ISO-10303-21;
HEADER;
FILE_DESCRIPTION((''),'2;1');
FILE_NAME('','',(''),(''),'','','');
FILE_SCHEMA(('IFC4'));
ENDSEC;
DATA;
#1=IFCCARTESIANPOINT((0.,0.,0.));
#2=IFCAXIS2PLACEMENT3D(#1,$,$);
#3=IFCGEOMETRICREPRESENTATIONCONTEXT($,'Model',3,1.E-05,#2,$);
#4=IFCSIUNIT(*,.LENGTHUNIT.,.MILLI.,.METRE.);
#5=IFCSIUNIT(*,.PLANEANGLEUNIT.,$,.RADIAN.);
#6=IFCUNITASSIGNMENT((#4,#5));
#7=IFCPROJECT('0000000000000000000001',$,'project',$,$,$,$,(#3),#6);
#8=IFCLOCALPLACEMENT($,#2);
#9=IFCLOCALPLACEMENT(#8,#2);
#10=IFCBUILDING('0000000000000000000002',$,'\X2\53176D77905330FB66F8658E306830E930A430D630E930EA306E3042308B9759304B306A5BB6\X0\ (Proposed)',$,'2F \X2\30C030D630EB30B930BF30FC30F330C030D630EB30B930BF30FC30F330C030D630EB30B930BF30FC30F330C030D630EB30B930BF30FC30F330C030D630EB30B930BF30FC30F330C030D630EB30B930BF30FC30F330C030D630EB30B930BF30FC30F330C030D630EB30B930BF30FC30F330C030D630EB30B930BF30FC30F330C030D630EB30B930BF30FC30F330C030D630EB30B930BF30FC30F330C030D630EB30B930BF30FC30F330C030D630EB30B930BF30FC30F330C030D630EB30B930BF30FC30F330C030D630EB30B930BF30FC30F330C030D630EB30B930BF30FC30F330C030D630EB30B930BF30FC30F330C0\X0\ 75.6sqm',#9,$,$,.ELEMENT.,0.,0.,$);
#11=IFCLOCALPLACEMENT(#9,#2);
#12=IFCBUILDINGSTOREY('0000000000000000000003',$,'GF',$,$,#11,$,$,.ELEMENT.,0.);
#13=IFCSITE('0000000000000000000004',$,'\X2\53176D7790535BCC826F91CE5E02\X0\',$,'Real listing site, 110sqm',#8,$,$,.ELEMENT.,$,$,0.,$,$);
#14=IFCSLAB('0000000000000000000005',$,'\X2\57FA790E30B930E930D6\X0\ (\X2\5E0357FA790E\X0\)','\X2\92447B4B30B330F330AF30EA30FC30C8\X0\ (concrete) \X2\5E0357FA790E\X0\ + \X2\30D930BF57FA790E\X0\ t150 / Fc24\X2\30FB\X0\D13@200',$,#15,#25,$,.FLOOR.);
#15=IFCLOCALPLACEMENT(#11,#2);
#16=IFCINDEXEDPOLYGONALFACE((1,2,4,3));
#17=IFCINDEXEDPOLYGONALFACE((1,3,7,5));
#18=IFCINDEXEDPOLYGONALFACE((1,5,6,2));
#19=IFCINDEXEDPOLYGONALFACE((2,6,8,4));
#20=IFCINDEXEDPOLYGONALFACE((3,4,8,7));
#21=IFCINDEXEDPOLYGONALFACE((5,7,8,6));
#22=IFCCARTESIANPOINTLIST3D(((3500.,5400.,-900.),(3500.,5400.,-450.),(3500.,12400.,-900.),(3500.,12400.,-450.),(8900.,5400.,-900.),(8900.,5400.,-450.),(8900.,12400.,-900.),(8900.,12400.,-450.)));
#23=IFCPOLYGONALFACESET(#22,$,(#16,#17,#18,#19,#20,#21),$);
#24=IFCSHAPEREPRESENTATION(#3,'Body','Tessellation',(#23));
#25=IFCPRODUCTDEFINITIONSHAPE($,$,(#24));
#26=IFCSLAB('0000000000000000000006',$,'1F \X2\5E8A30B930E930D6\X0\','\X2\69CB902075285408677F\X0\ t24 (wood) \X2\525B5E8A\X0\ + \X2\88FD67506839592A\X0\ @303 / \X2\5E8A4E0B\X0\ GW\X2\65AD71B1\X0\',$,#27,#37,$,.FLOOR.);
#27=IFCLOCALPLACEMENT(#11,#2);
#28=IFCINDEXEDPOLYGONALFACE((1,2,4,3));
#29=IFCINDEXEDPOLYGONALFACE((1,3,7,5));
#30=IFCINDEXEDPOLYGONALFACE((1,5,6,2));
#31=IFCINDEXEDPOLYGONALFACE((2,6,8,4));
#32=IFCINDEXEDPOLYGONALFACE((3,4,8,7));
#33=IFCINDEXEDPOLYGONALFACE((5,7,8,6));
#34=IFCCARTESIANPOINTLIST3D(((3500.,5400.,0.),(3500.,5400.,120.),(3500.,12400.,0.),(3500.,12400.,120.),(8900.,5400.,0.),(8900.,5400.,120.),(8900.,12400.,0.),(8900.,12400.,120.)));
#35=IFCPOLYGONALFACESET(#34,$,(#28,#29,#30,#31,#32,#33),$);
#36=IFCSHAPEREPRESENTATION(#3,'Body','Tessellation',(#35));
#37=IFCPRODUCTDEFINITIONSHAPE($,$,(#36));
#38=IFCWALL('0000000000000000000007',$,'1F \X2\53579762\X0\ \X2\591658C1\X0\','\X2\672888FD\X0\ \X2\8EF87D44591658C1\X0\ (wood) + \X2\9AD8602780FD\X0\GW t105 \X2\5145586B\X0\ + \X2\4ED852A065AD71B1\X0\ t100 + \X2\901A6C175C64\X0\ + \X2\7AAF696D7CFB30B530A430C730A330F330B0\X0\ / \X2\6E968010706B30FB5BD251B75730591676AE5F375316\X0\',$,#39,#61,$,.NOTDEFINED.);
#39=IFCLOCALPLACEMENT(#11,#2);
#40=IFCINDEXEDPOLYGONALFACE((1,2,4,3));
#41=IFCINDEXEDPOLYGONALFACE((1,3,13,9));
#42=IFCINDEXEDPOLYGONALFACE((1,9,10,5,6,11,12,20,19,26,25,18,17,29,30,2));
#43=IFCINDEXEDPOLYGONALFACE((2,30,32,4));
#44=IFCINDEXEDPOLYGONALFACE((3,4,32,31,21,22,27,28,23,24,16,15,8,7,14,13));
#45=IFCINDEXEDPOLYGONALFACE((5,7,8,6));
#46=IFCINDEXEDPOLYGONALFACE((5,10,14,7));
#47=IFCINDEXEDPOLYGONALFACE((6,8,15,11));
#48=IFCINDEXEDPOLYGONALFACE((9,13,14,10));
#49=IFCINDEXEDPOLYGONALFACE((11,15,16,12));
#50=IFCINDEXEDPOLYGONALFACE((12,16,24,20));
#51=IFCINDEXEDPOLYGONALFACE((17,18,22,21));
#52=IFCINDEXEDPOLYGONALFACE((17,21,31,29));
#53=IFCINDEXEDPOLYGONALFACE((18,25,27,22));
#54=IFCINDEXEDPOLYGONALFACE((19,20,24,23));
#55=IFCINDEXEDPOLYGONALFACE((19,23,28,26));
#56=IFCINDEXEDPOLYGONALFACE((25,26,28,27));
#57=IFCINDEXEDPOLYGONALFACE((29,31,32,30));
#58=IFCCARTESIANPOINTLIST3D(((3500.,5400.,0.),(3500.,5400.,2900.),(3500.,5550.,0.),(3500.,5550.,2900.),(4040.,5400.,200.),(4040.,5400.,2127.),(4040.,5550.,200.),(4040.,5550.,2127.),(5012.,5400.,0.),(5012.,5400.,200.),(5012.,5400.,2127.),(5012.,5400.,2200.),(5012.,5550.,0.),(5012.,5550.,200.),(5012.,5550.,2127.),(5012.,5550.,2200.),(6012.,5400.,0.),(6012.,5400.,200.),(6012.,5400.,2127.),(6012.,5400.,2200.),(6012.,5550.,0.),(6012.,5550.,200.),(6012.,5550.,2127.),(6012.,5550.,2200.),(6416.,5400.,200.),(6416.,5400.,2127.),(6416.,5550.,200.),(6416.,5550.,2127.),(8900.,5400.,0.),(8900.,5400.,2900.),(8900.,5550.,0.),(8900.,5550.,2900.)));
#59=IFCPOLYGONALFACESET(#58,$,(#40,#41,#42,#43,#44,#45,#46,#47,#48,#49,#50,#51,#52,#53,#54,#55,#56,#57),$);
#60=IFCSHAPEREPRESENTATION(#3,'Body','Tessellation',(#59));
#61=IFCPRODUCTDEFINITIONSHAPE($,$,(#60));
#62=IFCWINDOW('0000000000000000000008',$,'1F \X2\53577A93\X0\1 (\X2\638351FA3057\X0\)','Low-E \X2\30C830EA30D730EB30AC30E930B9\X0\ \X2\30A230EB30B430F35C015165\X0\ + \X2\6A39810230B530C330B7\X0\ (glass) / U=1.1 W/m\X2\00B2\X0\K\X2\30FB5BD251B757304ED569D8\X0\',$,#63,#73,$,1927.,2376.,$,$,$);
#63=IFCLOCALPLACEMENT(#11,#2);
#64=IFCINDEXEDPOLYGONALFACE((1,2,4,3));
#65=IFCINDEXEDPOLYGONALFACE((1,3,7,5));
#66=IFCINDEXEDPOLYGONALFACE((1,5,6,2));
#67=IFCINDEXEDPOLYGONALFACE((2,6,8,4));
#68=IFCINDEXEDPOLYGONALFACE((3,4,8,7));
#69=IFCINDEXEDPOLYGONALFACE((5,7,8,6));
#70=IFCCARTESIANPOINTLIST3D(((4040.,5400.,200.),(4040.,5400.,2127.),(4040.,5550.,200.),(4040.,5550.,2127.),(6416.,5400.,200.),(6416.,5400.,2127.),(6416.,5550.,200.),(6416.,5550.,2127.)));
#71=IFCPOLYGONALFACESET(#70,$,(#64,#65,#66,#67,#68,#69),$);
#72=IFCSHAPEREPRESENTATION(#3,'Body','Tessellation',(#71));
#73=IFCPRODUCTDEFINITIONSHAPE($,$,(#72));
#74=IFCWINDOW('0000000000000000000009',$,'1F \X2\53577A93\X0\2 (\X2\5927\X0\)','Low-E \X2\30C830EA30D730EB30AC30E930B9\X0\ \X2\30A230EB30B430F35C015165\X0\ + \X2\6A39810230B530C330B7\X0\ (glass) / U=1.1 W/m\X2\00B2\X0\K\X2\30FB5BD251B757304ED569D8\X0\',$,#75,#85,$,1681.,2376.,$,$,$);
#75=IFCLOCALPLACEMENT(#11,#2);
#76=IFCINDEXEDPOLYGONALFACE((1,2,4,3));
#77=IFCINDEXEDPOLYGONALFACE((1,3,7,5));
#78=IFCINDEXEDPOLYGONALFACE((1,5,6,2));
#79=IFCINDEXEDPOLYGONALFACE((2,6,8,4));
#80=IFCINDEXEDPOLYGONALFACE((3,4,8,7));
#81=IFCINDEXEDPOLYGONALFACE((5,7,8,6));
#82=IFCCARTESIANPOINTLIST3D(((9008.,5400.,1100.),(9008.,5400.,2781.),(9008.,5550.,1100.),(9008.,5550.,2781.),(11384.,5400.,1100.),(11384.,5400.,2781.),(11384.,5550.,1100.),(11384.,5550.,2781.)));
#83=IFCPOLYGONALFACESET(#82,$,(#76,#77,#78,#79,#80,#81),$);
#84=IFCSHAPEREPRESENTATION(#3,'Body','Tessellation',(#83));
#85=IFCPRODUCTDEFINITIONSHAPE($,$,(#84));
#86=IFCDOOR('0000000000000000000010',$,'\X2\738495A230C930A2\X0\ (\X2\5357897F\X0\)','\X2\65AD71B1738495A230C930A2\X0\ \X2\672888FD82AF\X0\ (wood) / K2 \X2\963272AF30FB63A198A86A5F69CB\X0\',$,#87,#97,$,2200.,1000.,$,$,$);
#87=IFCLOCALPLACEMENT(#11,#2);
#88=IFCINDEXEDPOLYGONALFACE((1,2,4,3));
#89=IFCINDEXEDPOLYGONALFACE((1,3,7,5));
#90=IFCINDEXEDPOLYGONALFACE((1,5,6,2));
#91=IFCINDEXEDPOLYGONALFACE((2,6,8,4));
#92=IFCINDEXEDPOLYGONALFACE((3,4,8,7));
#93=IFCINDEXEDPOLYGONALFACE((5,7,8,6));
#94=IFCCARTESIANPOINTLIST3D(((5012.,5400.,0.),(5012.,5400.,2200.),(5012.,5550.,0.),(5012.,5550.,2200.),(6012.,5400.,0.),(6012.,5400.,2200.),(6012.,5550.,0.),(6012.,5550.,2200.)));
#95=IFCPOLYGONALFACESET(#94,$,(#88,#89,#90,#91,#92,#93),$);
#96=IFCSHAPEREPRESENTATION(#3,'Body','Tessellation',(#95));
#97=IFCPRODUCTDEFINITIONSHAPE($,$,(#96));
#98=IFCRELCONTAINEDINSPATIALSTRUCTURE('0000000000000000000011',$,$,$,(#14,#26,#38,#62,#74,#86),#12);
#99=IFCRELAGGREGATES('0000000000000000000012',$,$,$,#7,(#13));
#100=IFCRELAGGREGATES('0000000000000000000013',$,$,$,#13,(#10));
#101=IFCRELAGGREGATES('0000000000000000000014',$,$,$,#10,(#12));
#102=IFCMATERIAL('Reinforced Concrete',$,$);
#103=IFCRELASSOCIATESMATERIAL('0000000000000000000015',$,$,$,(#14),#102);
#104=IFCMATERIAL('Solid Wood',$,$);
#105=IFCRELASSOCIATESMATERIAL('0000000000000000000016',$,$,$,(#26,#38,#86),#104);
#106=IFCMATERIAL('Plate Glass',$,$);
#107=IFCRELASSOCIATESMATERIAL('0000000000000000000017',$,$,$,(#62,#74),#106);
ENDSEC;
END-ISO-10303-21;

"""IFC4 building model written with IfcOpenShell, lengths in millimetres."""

from ifc_helpers import new_model, si_unit, frame, frame_2d, origin, place, context, project, spatial, rectangle, extrude, material, element, fill, save


model = new_model("IFC4")

# Units and contexts
model_context = context("Model", 3, precision=1e-05, world=origin())
ifc_project = project(units=[si_unit("LENGTHUNIT", "METRE", prefix="MILLI"), si_unit("PLANEANGLEUNIT", "RADIAN")], contexts=[model_context])

# Site, building, storey
site_placement = place(None, origin())
site = spatial("IfcSite", under=ifc_project, at=site_placement, Name="北海道富良野市", ObjectType="Real listing site, 110sqm", CompositionType="ELEMENT", RefElevation=0.0)
building_placement = place(site_placement, origin())
building = spatial("IfcBuilding", under=site, at=building_placement, Name="北海道・書斎とライブラリのある静かな家 (Proposed)", ObjectType="2F ダブルスターンダブルスターンダブルスターンダブルスターンダブルスターンダブルスターンダブルスターンダブルスターンダブルスターンダブルスターンダブルスターンダブルスターンダブルスターンダブルスターンダブルスターンダブルスターンダブルスターンダ 75.6sqm", CompositionType="ELEMENT", ElevationOfRefHeight=0.0, ElevationOfTerrain=0.0)
storey_placement = place(building_placement, origin())
storey = spatial("IfcBuildingStorey", under=building, at=storey_placement, Name="GF", CompositionType="ELEMENT", Elevation=0.0)

# Shared definitions
ifc_material_1 = material(Name="Solid Wood")

# Slabs
ifc_material_2 = material(Name="Reinforced Concrete")
slab_1_placement = place(storey_placement, frame((1750.0, 2700.0, -450.0)))
element("IfcSlab", 1, at=slab_1_placement, inside=storey, material=ifc_material_2, Name="基礎スラブ (布基礎)", Description="鉄筋コンクリート (concrete) 布基礎 + ベタ基礎 t150 / Fc24・D13@200", PredefinedType="FLOOR", context=model_context, shape_type="SweptSolid", body=[
    extrude(rectangle(XDim=5400.0, YDim=7000.0, at=frame_2d((2700.0, 3500.0))), frame((1750.0, 2700.0, -450.0)), (0.0, 0.0, 1.0), 450.0),
])
slab_2_placement = place(storey_placement, frame((1750.0, 2700.0, 0.0)))
element("IfcSlab", 2, at=slab_2_placement, inside=storey, material=ifc_material_1, Name="1F 床スラブ", Description="構造用合板 t24 (wood) 剛床 + 製材根太 @303 / 床下 GW断熱", PredefinedType="FLOOR", context=model_context, shape_type="SweptSolid", body=[
    extrude(rectangle(XDim=5400.0, YDim=7000.0, at=frame_2d((2700.0, 3500.0))), frame((1750.0, 2700.0, 0.0)), (0.0, 0.0, 1.0), 120.0),
])

# Wall, openings, windows, door
wall_1_placement = place(storey_placement, frame((1750.0, 2700.0, 0.0)))
wall_1 = element("IfcWall", 3, at=wall_1_placement, inside=storey, material=ifc_material_1, Name="1F 南面 外壁", Description="木製 軸組外壁 (wood) + 高性能GW t105 充填 + 付加断熱 t100 + 通気層 + 窯業系サイディング / 準耐火・寒冷地外皮強化", PredefinedType="NOTDEFINED", context=model_context, shape_type="SweptSolid", body=[
    extrude(rectangle(XDim=5400.0, YDim=150.0, at=frame_2d((2700.0, 75.0))), frame((1750.0, 2700.0, 0.0)), (0.0, 0.0, 1.0), 2900.0),
])
opening_1_placement = place(storey_placement, frame((2020.0, 2700.0, 100.0)))
opening_1 = element("IfcOpeningElement", 4, at=opening_1_placement, cuts=wall_1, PredefinedType="NOTDEFINED", context=model_context, shape_type="SweptSolid", body=[
    extrude(rectangle(XDim=2376.0, YDim=150.0, at=frame_2d((1188.0, 75.0))), frame((2020.0, 2700.0, 100.0)), (0.0, 0.0, 1.0), 1927.0),
])
opening_2_placement = place(storey_placement, frame((4504.0, 2700.0, 550.0)))
opening_2 = element("IfcOpeningElement", 5, at=opening_2_placement, cuts=wall_1, PredefinedType="NOTDEFINED", context=model_context, shape_type="SweptSolid", body=[
    extrude(rectangle(XDim=2376.0, YDim=150.0, at=frame_2d((1188.0, 75.0))), frame((4504.0, 2700.0, 550.0)), (0.0, 0.0, 1.0), 1681.0),
])
opening_3_placement = place(storey_placement, frame((2506.0, 2700.0, 0.0)))
opening_3 = element("IfcOpeningElement", 6, at=opening_3_placement, cuts=wall_1, PredefinedType="NOTDEFINED", context=model_context, shape_type="SweptSolid", body=[
    extrude(rectangle(XDim=1000.0, YDim=150.0, at=frame_2d((500.0, 75.0))), frame((2506.0, 2700.0, 0.0)), (0.0, 0.0, 1.0), 2200.0),
])
ifc_material_3 = material(Name="Plate Glass")
window_1_placement = place(storey_placement, frame((2020.0, 2700.0, 100.0)))
window_1 = element("IfcWindow", 7, at=window_1_placement, inside=storey, material=ifc_material_3, Name="1F 南窓1 (掃出し)", Description="Low-E トリプルガラス アルゴン封入 + 樹脂サッシ (glass) / U=1.1 W/m²K・寒冷地仕様", OverallHeight=1927.0, OverallWidth=2376.0, context=model_context, shape_type="SweptSolid", body=[
    extrude(rectangle(XDim=2376.0, YDim=150.0, at=frame_2d((1188.0, 75.0))), frame((2020.0, 2700.0, 100.0)), (0.0, 0.0, 1.0), 1927.0),
])
fill(opening_1, window_1)
window_2_placement = place(storey_placement, frame((4504.0, 2700.0, 550.0)))
window_2 = element("IfcWindow", 8, at=window_2_placement, inside=storey, material=ifc_material_3, Name="1F 南窓2 (大)", Description="Low-E トリプルガラス アルゴン封入 + 樹脂サッシ (glass) / U=1.1 W/m²K・寒冷地仕様", OverallHeight=1681.0, OverallWidth=2376.0, context=model_context, shape_type="SweptSolid", body=[
    extrude(rectangle(XDim=2376.0, YDim=150.0, at=frame_2d((1188.0, 75.0))), frame((4504.0, 2700.0, 550.0)), (0.0, 0.0, 1.0), 1681.0),
])
fill(opening_2, window_2)
door_placement = place(storey_placement, frame((2506.0, 2700.0, 0.0)))
door = element("IfcDoor", 9, at=door_placement, inside=storey, material=ifc_material_1, Name="玄関ドア (南西)", Description="断熱玄関ドア 木製芯 (wood) / K2 防犯・採風機構", OverallHeight=2200.0, OverallWidth=1000.0, context=model_context, shape_type="SweptSolid", body=[
    extrude(rectangle(XDim=1000.0, YDim=150.0, at=frame_2d((500.0, 75.0))), frame((2506.0, 2700.0, 0.0)), (0.0, 0.0, 1.0), 2200.0),
])
fill(opening_3, door)

save(model, "model.ifc")
